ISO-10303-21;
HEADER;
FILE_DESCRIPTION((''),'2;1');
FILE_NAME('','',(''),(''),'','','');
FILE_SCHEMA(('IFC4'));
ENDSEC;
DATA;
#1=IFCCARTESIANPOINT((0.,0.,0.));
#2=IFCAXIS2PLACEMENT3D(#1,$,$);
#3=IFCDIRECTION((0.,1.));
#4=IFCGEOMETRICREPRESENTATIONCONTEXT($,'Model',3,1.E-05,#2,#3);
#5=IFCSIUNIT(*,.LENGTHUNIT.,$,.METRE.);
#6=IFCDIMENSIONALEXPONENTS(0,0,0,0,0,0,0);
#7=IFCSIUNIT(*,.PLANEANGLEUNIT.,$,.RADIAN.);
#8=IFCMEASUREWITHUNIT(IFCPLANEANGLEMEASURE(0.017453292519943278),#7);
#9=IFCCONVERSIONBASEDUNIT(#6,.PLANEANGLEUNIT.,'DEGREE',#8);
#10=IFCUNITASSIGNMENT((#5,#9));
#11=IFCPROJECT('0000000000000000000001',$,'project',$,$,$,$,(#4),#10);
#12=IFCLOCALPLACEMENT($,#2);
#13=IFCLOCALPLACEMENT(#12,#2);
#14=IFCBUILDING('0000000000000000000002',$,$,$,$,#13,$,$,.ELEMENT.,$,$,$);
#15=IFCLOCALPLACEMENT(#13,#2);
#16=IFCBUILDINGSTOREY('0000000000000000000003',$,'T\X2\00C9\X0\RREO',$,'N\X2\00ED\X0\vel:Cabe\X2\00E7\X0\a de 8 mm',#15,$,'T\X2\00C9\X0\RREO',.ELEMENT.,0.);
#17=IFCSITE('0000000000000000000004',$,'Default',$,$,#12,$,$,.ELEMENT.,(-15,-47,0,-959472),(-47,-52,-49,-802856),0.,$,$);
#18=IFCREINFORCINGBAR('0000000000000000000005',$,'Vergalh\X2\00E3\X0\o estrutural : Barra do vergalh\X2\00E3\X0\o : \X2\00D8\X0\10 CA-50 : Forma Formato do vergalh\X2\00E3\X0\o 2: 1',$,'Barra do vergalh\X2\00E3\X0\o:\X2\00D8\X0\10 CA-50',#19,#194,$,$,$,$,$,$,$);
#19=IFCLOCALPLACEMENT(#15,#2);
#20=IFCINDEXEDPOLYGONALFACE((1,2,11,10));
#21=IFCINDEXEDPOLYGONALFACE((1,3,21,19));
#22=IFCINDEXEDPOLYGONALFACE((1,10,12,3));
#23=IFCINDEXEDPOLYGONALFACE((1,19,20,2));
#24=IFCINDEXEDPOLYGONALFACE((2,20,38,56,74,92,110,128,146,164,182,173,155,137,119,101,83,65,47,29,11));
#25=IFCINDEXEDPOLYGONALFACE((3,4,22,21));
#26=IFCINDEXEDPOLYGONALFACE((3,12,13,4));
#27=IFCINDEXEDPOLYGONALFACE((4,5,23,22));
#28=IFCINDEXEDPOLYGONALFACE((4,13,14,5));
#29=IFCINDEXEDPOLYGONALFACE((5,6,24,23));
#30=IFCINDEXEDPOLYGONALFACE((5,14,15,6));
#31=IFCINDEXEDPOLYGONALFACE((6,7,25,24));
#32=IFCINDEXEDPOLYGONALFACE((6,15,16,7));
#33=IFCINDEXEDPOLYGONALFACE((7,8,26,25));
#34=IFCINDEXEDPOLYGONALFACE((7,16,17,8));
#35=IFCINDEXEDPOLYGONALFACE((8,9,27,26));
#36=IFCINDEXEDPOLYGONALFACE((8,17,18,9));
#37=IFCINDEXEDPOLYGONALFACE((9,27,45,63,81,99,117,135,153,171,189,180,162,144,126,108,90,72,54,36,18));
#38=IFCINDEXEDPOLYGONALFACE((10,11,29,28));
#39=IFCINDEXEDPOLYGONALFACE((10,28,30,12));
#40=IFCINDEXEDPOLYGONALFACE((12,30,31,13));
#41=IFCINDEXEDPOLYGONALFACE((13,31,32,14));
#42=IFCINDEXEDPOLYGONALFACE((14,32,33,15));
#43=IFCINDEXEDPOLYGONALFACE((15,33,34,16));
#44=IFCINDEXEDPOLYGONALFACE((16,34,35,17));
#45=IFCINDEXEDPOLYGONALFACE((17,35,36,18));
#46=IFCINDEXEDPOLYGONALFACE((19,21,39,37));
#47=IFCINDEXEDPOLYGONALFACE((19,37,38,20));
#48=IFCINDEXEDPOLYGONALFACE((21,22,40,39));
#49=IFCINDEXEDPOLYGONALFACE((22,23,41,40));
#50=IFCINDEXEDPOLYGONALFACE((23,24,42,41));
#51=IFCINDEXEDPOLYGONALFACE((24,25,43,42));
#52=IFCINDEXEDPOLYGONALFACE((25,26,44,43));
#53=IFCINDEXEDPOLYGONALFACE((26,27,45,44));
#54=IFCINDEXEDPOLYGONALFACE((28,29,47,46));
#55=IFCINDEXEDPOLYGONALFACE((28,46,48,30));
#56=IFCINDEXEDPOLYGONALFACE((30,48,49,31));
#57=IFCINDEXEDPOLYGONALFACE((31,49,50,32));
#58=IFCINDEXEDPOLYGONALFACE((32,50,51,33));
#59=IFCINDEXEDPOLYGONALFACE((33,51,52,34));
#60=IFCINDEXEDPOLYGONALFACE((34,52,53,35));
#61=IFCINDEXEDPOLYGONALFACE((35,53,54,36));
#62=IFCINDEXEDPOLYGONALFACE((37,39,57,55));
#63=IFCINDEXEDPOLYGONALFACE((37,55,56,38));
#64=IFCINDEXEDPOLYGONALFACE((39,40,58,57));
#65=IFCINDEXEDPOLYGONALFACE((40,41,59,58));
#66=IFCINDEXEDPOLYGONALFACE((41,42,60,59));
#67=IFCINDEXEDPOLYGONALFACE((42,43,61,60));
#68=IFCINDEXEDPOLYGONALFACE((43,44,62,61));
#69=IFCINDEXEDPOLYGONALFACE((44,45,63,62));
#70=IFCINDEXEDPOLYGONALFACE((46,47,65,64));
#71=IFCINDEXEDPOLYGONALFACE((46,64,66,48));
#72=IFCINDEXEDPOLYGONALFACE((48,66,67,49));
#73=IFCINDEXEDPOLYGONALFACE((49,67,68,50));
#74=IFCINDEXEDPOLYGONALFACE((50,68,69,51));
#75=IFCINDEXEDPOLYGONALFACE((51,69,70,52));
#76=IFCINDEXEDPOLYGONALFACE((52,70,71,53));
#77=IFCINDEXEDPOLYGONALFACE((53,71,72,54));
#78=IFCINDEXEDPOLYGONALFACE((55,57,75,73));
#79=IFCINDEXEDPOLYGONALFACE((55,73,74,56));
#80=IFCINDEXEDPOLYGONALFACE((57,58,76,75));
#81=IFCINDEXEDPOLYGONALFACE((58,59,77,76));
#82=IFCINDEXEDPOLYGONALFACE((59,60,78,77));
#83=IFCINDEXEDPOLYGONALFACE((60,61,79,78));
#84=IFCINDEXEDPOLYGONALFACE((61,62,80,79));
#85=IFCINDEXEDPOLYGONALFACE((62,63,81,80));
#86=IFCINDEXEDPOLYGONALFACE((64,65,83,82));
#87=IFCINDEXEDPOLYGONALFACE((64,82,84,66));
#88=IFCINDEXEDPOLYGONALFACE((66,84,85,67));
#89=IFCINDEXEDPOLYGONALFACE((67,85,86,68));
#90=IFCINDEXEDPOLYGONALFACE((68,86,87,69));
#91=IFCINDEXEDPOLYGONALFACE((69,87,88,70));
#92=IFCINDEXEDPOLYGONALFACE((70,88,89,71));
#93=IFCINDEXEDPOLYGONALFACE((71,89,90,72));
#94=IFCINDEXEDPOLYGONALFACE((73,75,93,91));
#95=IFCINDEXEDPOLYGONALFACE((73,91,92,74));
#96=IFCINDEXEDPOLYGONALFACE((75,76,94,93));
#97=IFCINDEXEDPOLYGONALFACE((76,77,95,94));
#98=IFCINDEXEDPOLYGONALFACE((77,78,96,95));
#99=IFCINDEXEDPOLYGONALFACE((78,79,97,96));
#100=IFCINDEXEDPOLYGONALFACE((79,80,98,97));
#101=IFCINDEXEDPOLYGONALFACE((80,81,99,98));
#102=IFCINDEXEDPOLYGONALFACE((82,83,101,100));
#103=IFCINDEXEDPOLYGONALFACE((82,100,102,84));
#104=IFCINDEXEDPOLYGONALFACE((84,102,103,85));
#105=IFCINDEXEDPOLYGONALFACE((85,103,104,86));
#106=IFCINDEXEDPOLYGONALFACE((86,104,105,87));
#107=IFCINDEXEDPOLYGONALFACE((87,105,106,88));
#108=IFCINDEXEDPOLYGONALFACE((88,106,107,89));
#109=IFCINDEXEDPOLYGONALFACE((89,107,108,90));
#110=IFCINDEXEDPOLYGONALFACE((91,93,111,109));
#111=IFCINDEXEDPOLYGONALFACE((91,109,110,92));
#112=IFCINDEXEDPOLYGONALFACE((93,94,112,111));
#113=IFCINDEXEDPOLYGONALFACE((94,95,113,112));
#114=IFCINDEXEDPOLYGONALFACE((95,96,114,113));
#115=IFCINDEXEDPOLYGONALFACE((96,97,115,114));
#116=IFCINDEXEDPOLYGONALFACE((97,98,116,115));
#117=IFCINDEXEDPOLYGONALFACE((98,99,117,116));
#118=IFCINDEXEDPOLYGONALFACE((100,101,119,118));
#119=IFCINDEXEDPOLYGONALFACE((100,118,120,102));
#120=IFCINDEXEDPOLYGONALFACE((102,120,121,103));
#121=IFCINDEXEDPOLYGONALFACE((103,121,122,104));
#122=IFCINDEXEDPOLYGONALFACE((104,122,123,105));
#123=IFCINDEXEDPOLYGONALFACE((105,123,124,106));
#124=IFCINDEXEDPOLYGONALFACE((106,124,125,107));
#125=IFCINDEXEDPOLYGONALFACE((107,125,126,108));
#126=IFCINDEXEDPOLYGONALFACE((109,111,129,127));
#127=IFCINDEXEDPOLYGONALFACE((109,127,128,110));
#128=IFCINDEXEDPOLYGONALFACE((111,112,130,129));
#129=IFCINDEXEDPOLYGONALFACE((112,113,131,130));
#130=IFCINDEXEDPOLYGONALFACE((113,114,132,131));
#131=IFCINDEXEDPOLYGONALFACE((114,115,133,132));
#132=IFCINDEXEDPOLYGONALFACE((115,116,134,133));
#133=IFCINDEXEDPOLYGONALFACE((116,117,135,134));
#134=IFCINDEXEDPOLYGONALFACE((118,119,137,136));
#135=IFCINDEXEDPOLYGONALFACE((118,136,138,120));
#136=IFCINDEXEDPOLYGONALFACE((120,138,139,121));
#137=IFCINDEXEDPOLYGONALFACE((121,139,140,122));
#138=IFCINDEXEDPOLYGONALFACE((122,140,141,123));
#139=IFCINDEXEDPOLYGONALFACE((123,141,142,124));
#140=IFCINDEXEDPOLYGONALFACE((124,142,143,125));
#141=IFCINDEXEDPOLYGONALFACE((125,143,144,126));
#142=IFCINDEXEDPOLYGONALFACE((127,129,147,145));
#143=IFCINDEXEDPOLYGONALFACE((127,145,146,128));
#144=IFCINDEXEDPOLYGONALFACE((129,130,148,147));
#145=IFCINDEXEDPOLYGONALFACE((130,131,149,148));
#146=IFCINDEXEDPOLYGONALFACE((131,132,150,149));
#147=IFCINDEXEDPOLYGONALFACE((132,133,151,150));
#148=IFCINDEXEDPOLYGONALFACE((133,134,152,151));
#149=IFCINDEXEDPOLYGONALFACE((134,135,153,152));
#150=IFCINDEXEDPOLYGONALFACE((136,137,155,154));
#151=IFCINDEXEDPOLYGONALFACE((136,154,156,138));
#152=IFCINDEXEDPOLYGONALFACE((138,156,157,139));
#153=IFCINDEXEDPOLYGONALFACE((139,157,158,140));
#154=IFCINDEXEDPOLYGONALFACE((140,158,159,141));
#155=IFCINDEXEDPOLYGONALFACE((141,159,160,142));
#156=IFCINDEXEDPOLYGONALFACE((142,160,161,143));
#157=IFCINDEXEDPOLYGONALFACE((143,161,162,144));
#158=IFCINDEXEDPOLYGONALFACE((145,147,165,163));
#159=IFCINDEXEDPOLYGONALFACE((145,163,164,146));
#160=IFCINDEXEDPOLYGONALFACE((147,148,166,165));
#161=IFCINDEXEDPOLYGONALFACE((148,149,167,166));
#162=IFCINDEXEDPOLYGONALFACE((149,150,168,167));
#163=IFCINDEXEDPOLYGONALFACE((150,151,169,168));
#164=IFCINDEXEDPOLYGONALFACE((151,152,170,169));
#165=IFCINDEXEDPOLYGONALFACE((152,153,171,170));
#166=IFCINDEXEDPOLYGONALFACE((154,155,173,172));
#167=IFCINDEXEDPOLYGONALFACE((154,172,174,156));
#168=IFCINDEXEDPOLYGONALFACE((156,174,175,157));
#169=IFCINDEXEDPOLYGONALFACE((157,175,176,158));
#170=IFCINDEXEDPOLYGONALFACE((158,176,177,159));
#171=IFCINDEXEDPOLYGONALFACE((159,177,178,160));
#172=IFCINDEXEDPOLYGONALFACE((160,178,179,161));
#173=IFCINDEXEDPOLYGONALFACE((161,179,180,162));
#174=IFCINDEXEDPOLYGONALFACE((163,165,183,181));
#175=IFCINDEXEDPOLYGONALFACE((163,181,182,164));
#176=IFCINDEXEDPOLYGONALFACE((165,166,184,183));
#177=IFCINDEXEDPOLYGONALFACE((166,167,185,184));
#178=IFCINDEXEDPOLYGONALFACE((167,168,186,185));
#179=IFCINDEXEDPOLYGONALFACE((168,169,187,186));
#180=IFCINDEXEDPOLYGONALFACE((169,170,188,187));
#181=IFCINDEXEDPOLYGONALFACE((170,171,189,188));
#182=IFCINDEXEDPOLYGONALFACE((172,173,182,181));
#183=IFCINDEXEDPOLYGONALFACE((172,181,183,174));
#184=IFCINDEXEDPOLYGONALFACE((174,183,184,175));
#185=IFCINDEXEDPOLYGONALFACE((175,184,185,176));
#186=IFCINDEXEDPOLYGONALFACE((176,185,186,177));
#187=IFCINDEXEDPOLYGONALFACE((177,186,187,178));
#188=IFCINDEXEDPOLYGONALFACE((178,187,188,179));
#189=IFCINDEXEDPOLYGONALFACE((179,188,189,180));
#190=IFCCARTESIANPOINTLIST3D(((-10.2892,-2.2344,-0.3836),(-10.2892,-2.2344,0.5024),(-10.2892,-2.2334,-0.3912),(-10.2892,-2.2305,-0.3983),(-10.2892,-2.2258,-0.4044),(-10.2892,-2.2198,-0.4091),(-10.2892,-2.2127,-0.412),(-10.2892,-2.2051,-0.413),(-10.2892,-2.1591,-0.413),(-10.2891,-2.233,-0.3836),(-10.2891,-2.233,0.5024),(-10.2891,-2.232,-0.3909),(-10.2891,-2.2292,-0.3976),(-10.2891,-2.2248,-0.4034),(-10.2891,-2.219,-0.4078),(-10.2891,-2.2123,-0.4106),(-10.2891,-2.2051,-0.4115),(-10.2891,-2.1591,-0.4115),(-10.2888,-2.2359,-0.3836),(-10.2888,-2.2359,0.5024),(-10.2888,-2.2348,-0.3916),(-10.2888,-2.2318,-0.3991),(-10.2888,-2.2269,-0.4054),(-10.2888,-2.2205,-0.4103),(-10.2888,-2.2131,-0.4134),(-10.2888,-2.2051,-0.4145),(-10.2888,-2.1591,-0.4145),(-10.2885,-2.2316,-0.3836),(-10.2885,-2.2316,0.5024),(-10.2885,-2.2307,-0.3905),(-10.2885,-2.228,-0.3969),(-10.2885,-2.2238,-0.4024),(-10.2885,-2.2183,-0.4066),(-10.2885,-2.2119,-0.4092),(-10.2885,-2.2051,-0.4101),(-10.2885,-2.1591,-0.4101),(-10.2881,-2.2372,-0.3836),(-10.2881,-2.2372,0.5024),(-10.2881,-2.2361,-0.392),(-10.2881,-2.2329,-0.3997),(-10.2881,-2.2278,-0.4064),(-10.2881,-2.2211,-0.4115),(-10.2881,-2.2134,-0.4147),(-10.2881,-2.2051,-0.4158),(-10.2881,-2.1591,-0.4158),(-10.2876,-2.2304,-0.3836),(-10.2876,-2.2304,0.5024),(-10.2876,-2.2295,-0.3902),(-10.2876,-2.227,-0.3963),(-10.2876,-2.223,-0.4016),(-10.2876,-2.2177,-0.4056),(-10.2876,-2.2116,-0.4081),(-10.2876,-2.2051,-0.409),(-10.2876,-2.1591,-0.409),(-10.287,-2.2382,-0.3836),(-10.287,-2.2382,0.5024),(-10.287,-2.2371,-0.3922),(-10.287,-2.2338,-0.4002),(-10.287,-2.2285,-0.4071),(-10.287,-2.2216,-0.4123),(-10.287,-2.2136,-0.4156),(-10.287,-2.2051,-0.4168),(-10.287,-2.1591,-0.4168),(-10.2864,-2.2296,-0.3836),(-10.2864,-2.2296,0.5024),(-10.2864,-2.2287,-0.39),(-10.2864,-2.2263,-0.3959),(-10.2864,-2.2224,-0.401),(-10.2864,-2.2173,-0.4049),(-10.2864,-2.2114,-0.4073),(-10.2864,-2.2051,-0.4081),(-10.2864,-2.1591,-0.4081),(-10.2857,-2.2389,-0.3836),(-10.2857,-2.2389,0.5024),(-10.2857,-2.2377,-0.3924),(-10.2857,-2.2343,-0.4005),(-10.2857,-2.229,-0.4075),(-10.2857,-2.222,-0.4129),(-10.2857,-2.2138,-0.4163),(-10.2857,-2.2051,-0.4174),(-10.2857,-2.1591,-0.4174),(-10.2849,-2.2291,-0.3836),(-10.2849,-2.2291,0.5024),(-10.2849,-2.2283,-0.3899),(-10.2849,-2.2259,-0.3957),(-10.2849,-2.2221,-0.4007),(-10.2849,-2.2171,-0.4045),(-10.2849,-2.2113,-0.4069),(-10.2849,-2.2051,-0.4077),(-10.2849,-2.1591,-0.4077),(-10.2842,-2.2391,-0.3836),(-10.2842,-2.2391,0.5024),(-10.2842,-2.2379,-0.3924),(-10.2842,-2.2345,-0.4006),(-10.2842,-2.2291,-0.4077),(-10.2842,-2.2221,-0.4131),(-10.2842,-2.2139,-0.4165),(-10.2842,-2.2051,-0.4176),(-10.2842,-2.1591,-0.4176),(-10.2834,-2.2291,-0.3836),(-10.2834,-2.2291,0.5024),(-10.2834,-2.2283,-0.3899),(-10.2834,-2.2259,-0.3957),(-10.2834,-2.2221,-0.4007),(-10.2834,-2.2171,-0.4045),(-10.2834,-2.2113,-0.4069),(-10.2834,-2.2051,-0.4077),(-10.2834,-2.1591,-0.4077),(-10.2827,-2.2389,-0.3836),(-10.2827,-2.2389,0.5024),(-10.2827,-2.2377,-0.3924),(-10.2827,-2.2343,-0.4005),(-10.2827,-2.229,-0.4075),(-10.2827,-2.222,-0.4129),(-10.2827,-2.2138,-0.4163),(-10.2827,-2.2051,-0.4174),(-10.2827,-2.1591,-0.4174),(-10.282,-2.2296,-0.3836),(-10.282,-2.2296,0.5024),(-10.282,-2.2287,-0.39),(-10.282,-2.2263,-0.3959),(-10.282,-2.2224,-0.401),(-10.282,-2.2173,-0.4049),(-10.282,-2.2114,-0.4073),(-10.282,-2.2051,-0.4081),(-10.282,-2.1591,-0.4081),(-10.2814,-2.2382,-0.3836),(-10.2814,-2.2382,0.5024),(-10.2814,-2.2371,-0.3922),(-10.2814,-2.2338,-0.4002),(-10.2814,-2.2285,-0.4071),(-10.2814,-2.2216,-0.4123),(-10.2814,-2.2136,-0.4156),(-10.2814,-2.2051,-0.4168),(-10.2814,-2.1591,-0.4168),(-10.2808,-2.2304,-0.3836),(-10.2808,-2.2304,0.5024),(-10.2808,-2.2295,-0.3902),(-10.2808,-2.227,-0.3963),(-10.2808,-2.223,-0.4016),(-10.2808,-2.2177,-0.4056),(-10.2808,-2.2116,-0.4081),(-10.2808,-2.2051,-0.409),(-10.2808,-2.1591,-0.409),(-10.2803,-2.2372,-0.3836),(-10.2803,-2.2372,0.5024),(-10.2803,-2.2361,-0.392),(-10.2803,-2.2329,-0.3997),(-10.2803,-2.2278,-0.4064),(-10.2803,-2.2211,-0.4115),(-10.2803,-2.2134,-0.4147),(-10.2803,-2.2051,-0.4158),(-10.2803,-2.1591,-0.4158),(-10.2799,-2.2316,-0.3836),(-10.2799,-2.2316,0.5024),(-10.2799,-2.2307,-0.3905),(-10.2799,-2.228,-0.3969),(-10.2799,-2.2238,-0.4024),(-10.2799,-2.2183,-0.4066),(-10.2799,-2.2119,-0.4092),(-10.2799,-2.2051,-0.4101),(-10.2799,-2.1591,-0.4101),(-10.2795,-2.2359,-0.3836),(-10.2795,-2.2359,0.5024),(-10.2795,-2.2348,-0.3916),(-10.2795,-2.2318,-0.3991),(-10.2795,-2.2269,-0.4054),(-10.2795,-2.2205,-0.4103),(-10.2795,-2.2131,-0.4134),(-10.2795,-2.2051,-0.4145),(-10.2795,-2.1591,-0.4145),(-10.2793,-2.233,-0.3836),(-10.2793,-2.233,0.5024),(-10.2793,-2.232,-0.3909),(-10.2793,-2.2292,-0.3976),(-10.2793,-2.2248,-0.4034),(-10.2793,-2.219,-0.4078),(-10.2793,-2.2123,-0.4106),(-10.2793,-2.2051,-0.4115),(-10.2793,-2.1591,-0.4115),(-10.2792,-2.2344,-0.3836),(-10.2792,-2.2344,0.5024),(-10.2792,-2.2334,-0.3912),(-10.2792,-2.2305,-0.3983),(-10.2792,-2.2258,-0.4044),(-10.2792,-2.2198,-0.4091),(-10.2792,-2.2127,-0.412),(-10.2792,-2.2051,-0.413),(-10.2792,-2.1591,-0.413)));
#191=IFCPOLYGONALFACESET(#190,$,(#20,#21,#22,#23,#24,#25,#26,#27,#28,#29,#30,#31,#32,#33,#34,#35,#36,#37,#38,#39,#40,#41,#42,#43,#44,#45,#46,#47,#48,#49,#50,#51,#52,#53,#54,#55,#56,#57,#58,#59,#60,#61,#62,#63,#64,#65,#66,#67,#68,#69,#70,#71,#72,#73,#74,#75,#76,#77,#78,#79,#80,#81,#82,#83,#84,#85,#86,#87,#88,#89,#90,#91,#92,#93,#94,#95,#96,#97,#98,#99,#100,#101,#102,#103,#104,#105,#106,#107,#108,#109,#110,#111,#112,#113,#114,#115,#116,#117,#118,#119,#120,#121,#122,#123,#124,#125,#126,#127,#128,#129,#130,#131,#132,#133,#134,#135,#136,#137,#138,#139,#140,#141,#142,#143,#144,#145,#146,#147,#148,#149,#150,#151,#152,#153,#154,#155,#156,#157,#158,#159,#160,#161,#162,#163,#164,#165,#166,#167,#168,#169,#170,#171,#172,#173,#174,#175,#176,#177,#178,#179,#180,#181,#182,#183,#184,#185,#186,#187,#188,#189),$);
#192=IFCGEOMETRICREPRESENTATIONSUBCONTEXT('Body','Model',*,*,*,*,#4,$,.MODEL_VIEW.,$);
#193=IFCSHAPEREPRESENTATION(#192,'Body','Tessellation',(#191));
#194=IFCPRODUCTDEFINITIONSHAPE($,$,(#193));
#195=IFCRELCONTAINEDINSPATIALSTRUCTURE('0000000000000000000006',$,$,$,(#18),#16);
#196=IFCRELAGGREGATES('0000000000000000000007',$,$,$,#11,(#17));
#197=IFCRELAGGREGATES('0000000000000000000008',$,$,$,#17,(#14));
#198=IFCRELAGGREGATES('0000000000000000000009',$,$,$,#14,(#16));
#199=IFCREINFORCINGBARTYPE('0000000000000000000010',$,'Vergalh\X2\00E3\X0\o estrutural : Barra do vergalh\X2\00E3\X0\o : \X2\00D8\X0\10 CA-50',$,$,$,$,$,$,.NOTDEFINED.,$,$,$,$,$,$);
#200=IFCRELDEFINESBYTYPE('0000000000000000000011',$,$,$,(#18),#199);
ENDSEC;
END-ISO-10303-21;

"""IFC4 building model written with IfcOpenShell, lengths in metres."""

from ifc_helpers import new_model, entity, si_unit, converted_unit, direction, origin, place, context, subcontext, project, spatial, type_object, element, save


model = new_model("IFC4")

# Units and contexts
model_context = context("Model", 3, precision=1e-05, world=origin(), true_north=direction((0.0, 1.0)))
body_context = subcontext(model_context, "Body", "Model", "MODEL_VIEW")
ifc_project = project(units=[si_unit("LENGTHUNIT", "METRE"), converted_unit("PLANEANGLEUNIT", "DEGREE", entity("IfcPlaneAngleMeasure", 0.017453292519943278), si_unit("PLANEANGLEUNIT", "RADIAN"), dimensions=[0, 0, 0, 0, 0, 0, 0])], contexts=[model_context])

# Site, building, storey
site_placement = place(None, origin())
site = spatial("IfcSite", under=ifc_project, at=site_placement, Name="Default", CompositionType="ELEMENT", RefLatitude=(-15, -47, 0, -959472), RefLongitude=(-47, -52, -49, -802856), RefElevation=0.0)
building_placement = place(site_placement, origin())
building = spatial("IfcBuilding", under=site, at=building_placement, CompositionType="ELEMENT")
storey_placement = place(building_placement, origin())
storey = spatial("IfcBuildingStorey", under=building, at=storey_placement, Name="TÉRREO", ObjectType="Nível:Cabeça de 8 mm", LongName="TÉRREO", CompositionType="ELEMENT", Elevation=0.0)

# Reinforcing bar
reinforcing_bar_type_1 = type_object("IfcReinforcingBarType", Name="Vergalhão estrutural : Barra do vergalhão : Ø10 CA-50", PredefinedType="NOTDEFINED")
reinforcing_bar_1_placement = place(storey_placement, origin())
element("IfcReinforcingBar", 1, at=reinforcing_bar_1_placement, inside=storey, type_object=reinforcing_bar_type_1, Name="Vergalhão estrutural : Barra do vergalhão : Ø10 CA-50 : Forma Formato do vergalhão 2: 1", ObjectType="Barra do vergalhão:Ø10 CA-50", context=body_context, shape_type="AdvancedSweptSolid", body=[
    entity("IfcSweptDiskSolid", entity("IfcIndexedPolyCurve", entity("IfcCartesianPointList3D", [[-10.2842, -2.1591, -0.4126], [-10.2842, -2.2051, -0.4126], [-10.2842, -2.2256, -0.4042], [-10.2842, -2.2341, -0.3836], [-10.2842, -2.2341, 0.5024]]), [entity("IfcLineIndex", [1, 2]), entity("IfcArcIndex", [2, 3, 4]), entity("IfcLineIndex", [4, 5])], False), 0.005, None, 0.0, 92.0),
])

save(model, "model.ifc")
